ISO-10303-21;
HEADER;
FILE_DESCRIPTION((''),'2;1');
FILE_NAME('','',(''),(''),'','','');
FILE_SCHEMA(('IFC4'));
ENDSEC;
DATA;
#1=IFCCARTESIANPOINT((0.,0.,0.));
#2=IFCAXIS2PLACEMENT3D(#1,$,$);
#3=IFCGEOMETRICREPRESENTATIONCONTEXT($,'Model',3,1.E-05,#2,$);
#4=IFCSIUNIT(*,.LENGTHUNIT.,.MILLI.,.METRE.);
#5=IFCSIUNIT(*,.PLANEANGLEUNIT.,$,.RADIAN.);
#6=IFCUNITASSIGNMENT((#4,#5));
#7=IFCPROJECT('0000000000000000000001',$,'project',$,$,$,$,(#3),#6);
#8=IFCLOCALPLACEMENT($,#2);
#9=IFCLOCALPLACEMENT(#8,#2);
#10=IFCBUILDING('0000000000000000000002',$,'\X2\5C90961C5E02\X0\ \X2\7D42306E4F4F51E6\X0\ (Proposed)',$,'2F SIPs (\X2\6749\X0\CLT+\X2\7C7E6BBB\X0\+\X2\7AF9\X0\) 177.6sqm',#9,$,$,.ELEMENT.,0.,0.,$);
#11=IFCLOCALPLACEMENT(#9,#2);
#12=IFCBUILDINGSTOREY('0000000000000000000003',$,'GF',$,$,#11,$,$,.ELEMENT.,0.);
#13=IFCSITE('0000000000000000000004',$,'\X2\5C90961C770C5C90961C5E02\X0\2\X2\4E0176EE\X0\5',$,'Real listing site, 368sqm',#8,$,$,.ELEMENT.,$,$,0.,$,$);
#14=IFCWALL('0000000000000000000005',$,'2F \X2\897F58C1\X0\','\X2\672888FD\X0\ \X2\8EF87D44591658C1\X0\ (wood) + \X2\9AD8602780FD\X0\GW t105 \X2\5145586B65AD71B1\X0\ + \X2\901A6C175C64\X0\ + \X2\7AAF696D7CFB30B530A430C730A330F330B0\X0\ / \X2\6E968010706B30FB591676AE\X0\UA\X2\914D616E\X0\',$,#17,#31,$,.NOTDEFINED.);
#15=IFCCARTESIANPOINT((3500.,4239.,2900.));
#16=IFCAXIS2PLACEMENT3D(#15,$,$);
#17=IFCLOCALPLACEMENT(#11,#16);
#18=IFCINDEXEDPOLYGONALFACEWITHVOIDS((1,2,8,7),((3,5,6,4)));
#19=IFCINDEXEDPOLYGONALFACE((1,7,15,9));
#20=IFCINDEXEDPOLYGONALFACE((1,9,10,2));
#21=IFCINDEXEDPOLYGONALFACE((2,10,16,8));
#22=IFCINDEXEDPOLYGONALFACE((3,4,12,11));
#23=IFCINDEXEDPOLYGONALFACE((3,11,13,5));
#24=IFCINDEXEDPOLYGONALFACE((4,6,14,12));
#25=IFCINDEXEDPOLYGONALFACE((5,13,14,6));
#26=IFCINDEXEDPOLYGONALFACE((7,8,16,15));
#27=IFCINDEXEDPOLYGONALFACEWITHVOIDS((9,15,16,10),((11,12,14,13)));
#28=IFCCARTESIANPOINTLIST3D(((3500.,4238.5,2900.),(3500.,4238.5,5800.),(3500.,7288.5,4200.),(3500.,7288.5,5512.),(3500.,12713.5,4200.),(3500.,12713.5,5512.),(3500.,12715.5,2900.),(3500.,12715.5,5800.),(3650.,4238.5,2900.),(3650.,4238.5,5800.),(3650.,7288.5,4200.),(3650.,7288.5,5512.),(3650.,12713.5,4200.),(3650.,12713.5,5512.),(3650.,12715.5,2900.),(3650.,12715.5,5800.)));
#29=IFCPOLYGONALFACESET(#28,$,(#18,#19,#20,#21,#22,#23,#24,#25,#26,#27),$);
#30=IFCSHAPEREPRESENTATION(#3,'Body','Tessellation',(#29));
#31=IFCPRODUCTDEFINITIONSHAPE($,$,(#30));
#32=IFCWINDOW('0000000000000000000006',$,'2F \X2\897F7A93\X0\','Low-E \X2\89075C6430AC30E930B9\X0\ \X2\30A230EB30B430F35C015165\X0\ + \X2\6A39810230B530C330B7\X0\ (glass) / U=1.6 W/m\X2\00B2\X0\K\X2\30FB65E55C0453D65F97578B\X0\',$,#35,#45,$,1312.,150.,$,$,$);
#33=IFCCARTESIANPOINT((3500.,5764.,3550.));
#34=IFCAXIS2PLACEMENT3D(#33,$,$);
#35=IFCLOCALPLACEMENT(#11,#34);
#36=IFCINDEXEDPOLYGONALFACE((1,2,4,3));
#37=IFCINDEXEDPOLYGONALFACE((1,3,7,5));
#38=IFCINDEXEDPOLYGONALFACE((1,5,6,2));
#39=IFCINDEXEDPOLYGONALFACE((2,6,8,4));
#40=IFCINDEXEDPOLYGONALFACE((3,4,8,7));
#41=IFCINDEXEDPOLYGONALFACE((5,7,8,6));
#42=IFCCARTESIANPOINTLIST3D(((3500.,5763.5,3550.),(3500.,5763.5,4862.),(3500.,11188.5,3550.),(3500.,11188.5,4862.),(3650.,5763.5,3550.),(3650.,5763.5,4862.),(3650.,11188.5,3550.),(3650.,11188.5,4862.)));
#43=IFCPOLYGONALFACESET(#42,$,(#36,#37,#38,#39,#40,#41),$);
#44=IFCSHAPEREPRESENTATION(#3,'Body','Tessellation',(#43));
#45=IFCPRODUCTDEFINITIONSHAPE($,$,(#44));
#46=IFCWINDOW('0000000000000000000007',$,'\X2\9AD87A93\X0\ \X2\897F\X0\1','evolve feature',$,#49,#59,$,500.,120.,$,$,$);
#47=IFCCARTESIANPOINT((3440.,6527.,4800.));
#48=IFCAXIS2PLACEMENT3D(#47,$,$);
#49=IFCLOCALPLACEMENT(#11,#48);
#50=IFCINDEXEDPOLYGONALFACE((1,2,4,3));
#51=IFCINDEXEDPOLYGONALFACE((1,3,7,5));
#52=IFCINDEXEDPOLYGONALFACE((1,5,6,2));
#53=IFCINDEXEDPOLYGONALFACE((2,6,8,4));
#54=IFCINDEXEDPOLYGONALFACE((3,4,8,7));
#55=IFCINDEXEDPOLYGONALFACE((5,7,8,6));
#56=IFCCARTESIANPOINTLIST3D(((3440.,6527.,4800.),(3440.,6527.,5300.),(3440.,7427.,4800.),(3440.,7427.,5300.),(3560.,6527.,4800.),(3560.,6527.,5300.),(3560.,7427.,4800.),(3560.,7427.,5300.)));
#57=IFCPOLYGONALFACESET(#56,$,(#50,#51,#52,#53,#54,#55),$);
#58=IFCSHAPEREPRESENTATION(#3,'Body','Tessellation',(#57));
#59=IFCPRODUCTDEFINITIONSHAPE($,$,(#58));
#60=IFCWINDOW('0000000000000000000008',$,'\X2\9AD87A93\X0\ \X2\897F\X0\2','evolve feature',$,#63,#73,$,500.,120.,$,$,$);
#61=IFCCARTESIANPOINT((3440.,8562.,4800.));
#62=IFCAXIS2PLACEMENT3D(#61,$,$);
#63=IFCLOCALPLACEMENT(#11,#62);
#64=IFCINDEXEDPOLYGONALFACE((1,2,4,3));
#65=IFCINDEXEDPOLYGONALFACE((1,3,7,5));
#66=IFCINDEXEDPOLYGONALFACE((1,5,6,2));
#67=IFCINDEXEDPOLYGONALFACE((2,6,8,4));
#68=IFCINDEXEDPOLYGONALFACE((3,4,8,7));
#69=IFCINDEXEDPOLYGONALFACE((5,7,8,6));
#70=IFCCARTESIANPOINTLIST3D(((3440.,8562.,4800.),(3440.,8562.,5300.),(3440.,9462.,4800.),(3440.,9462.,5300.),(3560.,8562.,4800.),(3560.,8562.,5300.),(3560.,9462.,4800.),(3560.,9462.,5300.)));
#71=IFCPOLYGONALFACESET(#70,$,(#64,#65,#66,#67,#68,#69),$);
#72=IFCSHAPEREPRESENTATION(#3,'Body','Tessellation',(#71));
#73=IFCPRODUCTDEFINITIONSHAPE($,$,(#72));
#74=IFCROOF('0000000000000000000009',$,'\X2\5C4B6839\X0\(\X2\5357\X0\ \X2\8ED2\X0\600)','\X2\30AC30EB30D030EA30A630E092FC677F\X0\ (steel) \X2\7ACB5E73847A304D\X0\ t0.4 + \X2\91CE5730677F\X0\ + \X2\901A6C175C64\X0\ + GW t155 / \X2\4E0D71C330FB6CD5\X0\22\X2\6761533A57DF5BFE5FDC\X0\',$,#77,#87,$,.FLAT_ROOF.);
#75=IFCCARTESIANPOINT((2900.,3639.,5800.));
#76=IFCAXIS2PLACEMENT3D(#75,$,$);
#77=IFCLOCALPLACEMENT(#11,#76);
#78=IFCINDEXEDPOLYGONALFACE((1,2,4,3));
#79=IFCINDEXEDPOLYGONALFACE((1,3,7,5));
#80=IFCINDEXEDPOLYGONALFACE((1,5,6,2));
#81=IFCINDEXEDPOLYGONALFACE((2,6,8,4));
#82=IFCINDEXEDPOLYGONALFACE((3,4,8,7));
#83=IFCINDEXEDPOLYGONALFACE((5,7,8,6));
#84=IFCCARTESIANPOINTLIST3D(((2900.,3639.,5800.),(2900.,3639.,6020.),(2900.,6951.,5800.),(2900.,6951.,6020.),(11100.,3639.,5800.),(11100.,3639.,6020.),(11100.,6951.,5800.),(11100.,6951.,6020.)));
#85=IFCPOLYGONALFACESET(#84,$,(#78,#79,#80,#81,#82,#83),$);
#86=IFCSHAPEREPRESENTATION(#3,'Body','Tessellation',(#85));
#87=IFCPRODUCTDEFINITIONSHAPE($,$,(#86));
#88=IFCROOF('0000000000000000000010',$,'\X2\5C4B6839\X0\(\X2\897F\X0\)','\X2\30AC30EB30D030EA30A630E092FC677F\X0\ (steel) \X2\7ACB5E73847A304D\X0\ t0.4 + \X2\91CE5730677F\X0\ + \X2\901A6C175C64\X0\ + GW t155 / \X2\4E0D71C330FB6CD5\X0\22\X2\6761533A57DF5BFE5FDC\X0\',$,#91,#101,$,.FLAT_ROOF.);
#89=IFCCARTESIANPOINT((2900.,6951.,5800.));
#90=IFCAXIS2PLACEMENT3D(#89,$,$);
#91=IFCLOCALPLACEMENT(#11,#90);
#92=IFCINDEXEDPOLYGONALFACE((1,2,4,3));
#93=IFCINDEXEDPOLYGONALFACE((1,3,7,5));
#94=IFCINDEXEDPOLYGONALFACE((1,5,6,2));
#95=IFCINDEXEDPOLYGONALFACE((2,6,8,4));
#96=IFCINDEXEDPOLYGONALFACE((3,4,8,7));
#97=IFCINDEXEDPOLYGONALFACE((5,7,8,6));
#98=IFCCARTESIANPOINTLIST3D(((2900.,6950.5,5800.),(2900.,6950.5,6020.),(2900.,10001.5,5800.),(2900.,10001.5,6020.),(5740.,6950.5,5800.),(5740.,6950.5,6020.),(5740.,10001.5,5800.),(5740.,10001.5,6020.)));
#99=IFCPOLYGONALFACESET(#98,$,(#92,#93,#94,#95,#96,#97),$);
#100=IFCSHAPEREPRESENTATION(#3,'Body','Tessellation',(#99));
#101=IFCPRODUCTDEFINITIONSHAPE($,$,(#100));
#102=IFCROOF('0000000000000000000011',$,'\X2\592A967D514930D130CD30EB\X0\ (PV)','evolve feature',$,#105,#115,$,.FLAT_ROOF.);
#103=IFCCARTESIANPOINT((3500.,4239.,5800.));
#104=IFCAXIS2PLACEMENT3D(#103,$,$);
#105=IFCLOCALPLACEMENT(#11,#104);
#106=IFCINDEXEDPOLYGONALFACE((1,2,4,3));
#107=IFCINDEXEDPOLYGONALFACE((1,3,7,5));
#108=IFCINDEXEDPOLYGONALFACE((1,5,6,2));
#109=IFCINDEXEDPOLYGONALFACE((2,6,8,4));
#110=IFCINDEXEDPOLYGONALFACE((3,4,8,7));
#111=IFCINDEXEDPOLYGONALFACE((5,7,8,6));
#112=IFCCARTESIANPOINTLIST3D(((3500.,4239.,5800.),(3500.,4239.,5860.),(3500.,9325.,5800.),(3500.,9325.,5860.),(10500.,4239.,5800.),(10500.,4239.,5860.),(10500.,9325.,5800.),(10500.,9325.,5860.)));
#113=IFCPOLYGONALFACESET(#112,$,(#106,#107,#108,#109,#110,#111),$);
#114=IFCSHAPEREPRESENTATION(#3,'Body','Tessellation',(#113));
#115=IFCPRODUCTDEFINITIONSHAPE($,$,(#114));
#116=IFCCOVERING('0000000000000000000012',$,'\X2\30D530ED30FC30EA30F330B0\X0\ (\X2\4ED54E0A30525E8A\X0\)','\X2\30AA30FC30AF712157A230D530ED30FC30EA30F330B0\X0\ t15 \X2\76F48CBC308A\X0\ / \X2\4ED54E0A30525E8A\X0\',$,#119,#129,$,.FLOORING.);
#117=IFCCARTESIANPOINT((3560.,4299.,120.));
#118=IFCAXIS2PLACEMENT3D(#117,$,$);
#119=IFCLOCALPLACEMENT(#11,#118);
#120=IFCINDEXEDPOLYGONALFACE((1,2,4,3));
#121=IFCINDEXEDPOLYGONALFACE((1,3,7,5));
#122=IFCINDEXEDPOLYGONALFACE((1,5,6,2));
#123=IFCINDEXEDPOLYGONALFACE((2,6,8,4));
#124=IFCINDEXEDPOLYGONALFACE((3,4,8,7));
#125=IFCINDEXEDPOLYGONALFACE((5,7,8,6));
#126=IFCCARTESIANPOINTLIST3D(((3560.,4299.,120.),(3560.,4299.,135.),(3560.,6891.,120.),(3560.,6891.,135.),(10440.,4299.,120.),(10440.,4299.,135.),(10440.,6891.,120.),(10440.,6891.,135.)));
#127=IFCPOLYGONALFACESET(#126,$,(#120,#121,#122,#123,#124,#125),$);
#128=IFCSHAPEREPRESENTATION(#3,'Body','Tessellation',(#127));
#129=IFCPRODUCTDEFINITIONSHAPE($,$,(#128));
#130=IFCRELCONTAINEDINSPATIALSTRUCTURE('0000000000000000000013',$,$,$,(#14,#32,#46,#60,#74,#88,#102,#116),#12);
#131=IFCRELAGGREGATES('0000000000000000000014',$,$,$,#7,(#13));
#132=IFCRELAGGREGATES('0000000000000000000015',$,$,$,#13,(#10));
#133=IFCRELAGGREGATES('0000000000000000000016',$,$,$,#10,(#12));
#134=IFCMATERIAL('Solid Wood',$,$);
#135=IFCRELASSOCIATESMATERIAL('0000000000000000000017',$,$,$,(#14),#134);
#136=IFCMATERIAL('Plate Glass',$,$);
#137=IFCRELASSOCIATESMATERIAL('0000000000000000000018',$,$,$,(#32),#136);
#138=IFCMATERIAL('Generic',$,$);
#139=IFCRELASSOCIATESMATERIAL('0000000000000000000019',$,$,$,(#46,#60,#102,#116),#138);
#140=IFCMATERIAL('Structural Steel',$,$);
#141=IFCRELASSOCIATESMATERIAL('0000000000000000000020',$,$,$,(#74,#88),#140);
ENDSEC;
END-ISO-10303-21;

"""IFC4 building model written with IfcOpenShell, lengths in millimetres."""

from ifc_helpers import new_model, si_unit, frame, frame_2d, origin, place, context, project, spatial, rectangle, extrude, material, element, fill, save


model = new_model("IFC4")

# Units and contexts
model_context = context("Model", 3, precision=1e-05, world=origin())
ifc_project = project(units=[si_unit("LENGTHUNIT", "METRE", prefix="MILLI"), si_unit("PLANEANGLEUNIT", "RADIAN")], contexts=[model_context])

# Site, building, storey
site_placement = place(None, origin())
site = spatial("IfcSite", under=ifc_project, at=site_placement, Name="岐阜県岐阜市2丁目5", ObjectType="Real listing site, 368sqm", CompositionType="ELEMENT", RefElevation=0.0)
building_placement = place(site_placement, origin())
building = spatial("IfcBuilding", under=site, at=building_placement, Name="岐阜市 終の住処 (Proposed)", ObjectType="2F SIPs (杉CLT+籾殻+竹) 177.6sqm", CompositionType="ELEMENT", ElevationOfRefHeight=0.0, ElevationOfTerrain=0.0)
storey_placement = place(building_placement, origin())
storey = spatial("IfcBuildingStorey", under=building, at=storey_placement, Name="GF", CompositionType="ELEMENT", Elevation=0.0)

# Shared definitions
ifc_material_1 = material(Name="Solid Wood")
ifc_material_2 = material(Name="Generic")

# Shared definitions
ifc_material_3 = material(Name="Plate Glass")

# Wall, openings, windows
wall_1_placement = place(storey_placement, frame((3500.0, 4239.0, 2900.0)))
wall_1 = element("IfcWall", 1, at=wall_1_placement, inside=storey, material=ifc_material_1, Name="2F 西壁", Description="木製 軸組外壁 (wood) + 高性能GW t105 充填断熱 + 通気層 + 窯業系サイディング / 準耐火・外皮UA配慮", PredefinedType="NOTDEFINED", context=model_context, shape_type="SweptSolid", body=[
    extrude(rectangle(XDim=150.0, YDim=8477.0, at=frame_2d((75.0, 4238.0))), frame((3500.0, 4239.0, 2900.0)), (0.0, 0.0, 1.0), 2900.0),
])
opening_1_placement = place(storey_placement, frame((3500.0, 5764.0, 3550.0)))
opening_1 = element("IfcOpeningElement", 2, at=opening_1_placement, cuts=wall_1, PredefinedType="NOTDEFINED", context=model_context, shape_type="SweptSolid", body=[
    extrude(rectangle(XDim=150.0, YDim=5425.0, at=frame_2d((75.0, 2712.0))), frame((3500.0, 5764.0, 3550.0)), (0.0, 0.0, 1.0), 1312.0),
])
opening_2_placement = place(storey_placement, frame((3440.0, 6527.0, 4800.0)))
opening_2 = element("IfcOpeningElement", 3, at=opening_2_placement, cuts=wall_1, PredefinedType="NOTDEFINED", context=model_context, shape_type="SweptSolid", body=[
    extrude(rectangle(XDim=120.0, YDim=900.0, at=frame_2d((60.0, 450.0))), frame((3440.0, 6527.0, 4800.0)), (0.0, 0.0, 1.0), 500.0),
])
opening_3_placement = place(storey_placement, frame((3440.0, 8562.0, 4800.0)))
opening_3 = element("IfcOpeningElement", 4, at=opening_3_placement, cuts=wall_1, PredefinedType="NOTDEFINED", context=model_context, shape_type="SweptSolid", body=[
    extrude(rectangle(XDim=120.0, YDim=900.0, at=frame_2d((60.0, 450.0))), frame((3440.0, 8562.0, 4800.0)), (0.0, 0.0, 1.0), 500.0),
])
window_1_placement = place(storey_placement, frame((3500.0, 5764.0, 3550.0)))
window_1 = element("IfcWindow", 5, at=window_1_placement, inside=storey, material=ifc_material_3, Name="2F 西窓", Description="Low-E 複層ガラス アルゴン封入 + 樹脂サッシ (glass) / U=1.6 W/m²K・日射取得型", OverallHeight=1312.0, OverallWidth=150.0, context=model_context, shape_type="SweptSolid", body=[
    extrude(rectangle(XDim=150.0, YDim=5425.0, at=frame_2d((75.0, 2712.0))), frame((3500.0, 5764.0, 3550.0)), (0.0, 0.0, 1.0), 1312.0),
])
fill(opening_1, window_1)
window_2_placement = place(storey_placement, frame((3440.0, 6527.0, 4800.0)))
window_2 = element("IfcWindow", 6, at=window_2_placement, inside=storey, material=ifc_material_2, Name="高窓 西1", Description="evolve feature", OverallHeight=500.0, OverallWidth=120.0, context=model_context, shape_type="SweptSolid", body=[
    extrude(rectangle(XDim=120.0, YDim=900.0, at=frame_2d((60.0, 450.0))), frame((3440.0, 6527.0, 4800.0)), (0.0, 0.0, 1.0), 500.0),
])
fill(opening_2, window_2)
window_3_placement = place(storey_placement, frame((3440.0, 8562.0, 4800.0)))
window_3 = element("IfcWindow", 7, at=window_3_placement, inside=storey, material=ifc_material_2, Name="高窓 西2", Description="evolve feature", OverallHeight=500.0, OverallWidth=120.0, context=model_context, shape_type="SweptSolid", body=[
    extrude(rectangle(XDim=120.0, YDim=900.0, at=frame_2d((60.0, 450.0))), frame((3440.0, 8562.0, 4800.0)), (0.0, 0.0, 1.0), 500.0),
])
fill(opening_3, window_3)

# Roofs
ifc_material_4 = material(Name="Structural Steel")
roof_1_placement = place(storey_placement, frame((2900.0, 3639.0, 5800.0)))
element("IfcRoof", 8, at=roof_1_placement, inside=storey, material=ifc_material_4, Name="屋根(南 軒600)", Description="ガルバリウム鋼板 (steel) 立平葺き t0.4 + 野地板 + 通気層 + GW t155 / 不燃・法22条区域対応", PredefinedType="FLAT_ROOF", context=model_context, shape_type="SweptSolid", body=[
    extrude(rectangle(XDim=8200.0, YDim=3312.0, at=frame_2d((4100.0, 1656.0))), frame((2900.0, 3639.0, 5800.0)), (0.0, 0.0, 1.0), 220.0),
])
roof_2_placement = place(storey_placement, frame((2900.0, 6951.0, 5800.0)))
element("IfcRoof", 9, at=roof_2_placement, inside=storey, material=ifc_material_4, Name="屋根(西)", Description="ガルバリウム鋼板 (steel) 立平葺き t0.4 + 野地板 + 通気層 + GW t155 / 不燃・法22条区域対応", PredefinedType="FLAT_ROOF", context=model_context, shape_type="SweptSolid", body=[
    extrude(rectangle(XDim=2840.0, YDim=3051.0, at=frame_2d((1420.0, 1525.0))), frame((2900.0, 6951.0, 5800.0)), (0.0, 0.0, 1.0), 220.0),
])
roof_3_placement = place(storey_placement, frame((3500.0, 4239.0, 5800.0)))
element("IfcRoof", 10, at=roof_3_placement, inside=storey, material=ifc_material_2, Name="太陽光パネル (PV)", Description="evolve feature", PredefinedType="FLAT_ROOF", context=model_context, shape_type="SweptSolid", body=[
    extrude(rectangle(XDim=7000.0, YDim=5086.0, at=frame_2d((3500.0, 2543.0))), frame((3500.0, 4239.0, 5800.0)), (0.0, 0.0, 1.0), 60.0),
])

# Covering
covering_placement = place(storey_placement, frame((3560.0, 4299.0, 120.0)))
element("IfcCovering", 11, at=covering_placement, inside=storey, material=ifc_material_2, Name="フローリング (仕上げ床)", Description="オーク無垢フローリング t15 直貼り / 仕上げ床", PredefinedType="FLOORING", context=model_context, shape_type="SweptSolid", body=[
    extrude(rectangle(XDim=6880.0, YDim=2592.0, at=frame_2d((3440.0, 1296.0))), frame((3560.0, 4299.0, 120.0)), (0.0, 0.0, 1.0), 15.0),
])

save(model, "model.ifc")
